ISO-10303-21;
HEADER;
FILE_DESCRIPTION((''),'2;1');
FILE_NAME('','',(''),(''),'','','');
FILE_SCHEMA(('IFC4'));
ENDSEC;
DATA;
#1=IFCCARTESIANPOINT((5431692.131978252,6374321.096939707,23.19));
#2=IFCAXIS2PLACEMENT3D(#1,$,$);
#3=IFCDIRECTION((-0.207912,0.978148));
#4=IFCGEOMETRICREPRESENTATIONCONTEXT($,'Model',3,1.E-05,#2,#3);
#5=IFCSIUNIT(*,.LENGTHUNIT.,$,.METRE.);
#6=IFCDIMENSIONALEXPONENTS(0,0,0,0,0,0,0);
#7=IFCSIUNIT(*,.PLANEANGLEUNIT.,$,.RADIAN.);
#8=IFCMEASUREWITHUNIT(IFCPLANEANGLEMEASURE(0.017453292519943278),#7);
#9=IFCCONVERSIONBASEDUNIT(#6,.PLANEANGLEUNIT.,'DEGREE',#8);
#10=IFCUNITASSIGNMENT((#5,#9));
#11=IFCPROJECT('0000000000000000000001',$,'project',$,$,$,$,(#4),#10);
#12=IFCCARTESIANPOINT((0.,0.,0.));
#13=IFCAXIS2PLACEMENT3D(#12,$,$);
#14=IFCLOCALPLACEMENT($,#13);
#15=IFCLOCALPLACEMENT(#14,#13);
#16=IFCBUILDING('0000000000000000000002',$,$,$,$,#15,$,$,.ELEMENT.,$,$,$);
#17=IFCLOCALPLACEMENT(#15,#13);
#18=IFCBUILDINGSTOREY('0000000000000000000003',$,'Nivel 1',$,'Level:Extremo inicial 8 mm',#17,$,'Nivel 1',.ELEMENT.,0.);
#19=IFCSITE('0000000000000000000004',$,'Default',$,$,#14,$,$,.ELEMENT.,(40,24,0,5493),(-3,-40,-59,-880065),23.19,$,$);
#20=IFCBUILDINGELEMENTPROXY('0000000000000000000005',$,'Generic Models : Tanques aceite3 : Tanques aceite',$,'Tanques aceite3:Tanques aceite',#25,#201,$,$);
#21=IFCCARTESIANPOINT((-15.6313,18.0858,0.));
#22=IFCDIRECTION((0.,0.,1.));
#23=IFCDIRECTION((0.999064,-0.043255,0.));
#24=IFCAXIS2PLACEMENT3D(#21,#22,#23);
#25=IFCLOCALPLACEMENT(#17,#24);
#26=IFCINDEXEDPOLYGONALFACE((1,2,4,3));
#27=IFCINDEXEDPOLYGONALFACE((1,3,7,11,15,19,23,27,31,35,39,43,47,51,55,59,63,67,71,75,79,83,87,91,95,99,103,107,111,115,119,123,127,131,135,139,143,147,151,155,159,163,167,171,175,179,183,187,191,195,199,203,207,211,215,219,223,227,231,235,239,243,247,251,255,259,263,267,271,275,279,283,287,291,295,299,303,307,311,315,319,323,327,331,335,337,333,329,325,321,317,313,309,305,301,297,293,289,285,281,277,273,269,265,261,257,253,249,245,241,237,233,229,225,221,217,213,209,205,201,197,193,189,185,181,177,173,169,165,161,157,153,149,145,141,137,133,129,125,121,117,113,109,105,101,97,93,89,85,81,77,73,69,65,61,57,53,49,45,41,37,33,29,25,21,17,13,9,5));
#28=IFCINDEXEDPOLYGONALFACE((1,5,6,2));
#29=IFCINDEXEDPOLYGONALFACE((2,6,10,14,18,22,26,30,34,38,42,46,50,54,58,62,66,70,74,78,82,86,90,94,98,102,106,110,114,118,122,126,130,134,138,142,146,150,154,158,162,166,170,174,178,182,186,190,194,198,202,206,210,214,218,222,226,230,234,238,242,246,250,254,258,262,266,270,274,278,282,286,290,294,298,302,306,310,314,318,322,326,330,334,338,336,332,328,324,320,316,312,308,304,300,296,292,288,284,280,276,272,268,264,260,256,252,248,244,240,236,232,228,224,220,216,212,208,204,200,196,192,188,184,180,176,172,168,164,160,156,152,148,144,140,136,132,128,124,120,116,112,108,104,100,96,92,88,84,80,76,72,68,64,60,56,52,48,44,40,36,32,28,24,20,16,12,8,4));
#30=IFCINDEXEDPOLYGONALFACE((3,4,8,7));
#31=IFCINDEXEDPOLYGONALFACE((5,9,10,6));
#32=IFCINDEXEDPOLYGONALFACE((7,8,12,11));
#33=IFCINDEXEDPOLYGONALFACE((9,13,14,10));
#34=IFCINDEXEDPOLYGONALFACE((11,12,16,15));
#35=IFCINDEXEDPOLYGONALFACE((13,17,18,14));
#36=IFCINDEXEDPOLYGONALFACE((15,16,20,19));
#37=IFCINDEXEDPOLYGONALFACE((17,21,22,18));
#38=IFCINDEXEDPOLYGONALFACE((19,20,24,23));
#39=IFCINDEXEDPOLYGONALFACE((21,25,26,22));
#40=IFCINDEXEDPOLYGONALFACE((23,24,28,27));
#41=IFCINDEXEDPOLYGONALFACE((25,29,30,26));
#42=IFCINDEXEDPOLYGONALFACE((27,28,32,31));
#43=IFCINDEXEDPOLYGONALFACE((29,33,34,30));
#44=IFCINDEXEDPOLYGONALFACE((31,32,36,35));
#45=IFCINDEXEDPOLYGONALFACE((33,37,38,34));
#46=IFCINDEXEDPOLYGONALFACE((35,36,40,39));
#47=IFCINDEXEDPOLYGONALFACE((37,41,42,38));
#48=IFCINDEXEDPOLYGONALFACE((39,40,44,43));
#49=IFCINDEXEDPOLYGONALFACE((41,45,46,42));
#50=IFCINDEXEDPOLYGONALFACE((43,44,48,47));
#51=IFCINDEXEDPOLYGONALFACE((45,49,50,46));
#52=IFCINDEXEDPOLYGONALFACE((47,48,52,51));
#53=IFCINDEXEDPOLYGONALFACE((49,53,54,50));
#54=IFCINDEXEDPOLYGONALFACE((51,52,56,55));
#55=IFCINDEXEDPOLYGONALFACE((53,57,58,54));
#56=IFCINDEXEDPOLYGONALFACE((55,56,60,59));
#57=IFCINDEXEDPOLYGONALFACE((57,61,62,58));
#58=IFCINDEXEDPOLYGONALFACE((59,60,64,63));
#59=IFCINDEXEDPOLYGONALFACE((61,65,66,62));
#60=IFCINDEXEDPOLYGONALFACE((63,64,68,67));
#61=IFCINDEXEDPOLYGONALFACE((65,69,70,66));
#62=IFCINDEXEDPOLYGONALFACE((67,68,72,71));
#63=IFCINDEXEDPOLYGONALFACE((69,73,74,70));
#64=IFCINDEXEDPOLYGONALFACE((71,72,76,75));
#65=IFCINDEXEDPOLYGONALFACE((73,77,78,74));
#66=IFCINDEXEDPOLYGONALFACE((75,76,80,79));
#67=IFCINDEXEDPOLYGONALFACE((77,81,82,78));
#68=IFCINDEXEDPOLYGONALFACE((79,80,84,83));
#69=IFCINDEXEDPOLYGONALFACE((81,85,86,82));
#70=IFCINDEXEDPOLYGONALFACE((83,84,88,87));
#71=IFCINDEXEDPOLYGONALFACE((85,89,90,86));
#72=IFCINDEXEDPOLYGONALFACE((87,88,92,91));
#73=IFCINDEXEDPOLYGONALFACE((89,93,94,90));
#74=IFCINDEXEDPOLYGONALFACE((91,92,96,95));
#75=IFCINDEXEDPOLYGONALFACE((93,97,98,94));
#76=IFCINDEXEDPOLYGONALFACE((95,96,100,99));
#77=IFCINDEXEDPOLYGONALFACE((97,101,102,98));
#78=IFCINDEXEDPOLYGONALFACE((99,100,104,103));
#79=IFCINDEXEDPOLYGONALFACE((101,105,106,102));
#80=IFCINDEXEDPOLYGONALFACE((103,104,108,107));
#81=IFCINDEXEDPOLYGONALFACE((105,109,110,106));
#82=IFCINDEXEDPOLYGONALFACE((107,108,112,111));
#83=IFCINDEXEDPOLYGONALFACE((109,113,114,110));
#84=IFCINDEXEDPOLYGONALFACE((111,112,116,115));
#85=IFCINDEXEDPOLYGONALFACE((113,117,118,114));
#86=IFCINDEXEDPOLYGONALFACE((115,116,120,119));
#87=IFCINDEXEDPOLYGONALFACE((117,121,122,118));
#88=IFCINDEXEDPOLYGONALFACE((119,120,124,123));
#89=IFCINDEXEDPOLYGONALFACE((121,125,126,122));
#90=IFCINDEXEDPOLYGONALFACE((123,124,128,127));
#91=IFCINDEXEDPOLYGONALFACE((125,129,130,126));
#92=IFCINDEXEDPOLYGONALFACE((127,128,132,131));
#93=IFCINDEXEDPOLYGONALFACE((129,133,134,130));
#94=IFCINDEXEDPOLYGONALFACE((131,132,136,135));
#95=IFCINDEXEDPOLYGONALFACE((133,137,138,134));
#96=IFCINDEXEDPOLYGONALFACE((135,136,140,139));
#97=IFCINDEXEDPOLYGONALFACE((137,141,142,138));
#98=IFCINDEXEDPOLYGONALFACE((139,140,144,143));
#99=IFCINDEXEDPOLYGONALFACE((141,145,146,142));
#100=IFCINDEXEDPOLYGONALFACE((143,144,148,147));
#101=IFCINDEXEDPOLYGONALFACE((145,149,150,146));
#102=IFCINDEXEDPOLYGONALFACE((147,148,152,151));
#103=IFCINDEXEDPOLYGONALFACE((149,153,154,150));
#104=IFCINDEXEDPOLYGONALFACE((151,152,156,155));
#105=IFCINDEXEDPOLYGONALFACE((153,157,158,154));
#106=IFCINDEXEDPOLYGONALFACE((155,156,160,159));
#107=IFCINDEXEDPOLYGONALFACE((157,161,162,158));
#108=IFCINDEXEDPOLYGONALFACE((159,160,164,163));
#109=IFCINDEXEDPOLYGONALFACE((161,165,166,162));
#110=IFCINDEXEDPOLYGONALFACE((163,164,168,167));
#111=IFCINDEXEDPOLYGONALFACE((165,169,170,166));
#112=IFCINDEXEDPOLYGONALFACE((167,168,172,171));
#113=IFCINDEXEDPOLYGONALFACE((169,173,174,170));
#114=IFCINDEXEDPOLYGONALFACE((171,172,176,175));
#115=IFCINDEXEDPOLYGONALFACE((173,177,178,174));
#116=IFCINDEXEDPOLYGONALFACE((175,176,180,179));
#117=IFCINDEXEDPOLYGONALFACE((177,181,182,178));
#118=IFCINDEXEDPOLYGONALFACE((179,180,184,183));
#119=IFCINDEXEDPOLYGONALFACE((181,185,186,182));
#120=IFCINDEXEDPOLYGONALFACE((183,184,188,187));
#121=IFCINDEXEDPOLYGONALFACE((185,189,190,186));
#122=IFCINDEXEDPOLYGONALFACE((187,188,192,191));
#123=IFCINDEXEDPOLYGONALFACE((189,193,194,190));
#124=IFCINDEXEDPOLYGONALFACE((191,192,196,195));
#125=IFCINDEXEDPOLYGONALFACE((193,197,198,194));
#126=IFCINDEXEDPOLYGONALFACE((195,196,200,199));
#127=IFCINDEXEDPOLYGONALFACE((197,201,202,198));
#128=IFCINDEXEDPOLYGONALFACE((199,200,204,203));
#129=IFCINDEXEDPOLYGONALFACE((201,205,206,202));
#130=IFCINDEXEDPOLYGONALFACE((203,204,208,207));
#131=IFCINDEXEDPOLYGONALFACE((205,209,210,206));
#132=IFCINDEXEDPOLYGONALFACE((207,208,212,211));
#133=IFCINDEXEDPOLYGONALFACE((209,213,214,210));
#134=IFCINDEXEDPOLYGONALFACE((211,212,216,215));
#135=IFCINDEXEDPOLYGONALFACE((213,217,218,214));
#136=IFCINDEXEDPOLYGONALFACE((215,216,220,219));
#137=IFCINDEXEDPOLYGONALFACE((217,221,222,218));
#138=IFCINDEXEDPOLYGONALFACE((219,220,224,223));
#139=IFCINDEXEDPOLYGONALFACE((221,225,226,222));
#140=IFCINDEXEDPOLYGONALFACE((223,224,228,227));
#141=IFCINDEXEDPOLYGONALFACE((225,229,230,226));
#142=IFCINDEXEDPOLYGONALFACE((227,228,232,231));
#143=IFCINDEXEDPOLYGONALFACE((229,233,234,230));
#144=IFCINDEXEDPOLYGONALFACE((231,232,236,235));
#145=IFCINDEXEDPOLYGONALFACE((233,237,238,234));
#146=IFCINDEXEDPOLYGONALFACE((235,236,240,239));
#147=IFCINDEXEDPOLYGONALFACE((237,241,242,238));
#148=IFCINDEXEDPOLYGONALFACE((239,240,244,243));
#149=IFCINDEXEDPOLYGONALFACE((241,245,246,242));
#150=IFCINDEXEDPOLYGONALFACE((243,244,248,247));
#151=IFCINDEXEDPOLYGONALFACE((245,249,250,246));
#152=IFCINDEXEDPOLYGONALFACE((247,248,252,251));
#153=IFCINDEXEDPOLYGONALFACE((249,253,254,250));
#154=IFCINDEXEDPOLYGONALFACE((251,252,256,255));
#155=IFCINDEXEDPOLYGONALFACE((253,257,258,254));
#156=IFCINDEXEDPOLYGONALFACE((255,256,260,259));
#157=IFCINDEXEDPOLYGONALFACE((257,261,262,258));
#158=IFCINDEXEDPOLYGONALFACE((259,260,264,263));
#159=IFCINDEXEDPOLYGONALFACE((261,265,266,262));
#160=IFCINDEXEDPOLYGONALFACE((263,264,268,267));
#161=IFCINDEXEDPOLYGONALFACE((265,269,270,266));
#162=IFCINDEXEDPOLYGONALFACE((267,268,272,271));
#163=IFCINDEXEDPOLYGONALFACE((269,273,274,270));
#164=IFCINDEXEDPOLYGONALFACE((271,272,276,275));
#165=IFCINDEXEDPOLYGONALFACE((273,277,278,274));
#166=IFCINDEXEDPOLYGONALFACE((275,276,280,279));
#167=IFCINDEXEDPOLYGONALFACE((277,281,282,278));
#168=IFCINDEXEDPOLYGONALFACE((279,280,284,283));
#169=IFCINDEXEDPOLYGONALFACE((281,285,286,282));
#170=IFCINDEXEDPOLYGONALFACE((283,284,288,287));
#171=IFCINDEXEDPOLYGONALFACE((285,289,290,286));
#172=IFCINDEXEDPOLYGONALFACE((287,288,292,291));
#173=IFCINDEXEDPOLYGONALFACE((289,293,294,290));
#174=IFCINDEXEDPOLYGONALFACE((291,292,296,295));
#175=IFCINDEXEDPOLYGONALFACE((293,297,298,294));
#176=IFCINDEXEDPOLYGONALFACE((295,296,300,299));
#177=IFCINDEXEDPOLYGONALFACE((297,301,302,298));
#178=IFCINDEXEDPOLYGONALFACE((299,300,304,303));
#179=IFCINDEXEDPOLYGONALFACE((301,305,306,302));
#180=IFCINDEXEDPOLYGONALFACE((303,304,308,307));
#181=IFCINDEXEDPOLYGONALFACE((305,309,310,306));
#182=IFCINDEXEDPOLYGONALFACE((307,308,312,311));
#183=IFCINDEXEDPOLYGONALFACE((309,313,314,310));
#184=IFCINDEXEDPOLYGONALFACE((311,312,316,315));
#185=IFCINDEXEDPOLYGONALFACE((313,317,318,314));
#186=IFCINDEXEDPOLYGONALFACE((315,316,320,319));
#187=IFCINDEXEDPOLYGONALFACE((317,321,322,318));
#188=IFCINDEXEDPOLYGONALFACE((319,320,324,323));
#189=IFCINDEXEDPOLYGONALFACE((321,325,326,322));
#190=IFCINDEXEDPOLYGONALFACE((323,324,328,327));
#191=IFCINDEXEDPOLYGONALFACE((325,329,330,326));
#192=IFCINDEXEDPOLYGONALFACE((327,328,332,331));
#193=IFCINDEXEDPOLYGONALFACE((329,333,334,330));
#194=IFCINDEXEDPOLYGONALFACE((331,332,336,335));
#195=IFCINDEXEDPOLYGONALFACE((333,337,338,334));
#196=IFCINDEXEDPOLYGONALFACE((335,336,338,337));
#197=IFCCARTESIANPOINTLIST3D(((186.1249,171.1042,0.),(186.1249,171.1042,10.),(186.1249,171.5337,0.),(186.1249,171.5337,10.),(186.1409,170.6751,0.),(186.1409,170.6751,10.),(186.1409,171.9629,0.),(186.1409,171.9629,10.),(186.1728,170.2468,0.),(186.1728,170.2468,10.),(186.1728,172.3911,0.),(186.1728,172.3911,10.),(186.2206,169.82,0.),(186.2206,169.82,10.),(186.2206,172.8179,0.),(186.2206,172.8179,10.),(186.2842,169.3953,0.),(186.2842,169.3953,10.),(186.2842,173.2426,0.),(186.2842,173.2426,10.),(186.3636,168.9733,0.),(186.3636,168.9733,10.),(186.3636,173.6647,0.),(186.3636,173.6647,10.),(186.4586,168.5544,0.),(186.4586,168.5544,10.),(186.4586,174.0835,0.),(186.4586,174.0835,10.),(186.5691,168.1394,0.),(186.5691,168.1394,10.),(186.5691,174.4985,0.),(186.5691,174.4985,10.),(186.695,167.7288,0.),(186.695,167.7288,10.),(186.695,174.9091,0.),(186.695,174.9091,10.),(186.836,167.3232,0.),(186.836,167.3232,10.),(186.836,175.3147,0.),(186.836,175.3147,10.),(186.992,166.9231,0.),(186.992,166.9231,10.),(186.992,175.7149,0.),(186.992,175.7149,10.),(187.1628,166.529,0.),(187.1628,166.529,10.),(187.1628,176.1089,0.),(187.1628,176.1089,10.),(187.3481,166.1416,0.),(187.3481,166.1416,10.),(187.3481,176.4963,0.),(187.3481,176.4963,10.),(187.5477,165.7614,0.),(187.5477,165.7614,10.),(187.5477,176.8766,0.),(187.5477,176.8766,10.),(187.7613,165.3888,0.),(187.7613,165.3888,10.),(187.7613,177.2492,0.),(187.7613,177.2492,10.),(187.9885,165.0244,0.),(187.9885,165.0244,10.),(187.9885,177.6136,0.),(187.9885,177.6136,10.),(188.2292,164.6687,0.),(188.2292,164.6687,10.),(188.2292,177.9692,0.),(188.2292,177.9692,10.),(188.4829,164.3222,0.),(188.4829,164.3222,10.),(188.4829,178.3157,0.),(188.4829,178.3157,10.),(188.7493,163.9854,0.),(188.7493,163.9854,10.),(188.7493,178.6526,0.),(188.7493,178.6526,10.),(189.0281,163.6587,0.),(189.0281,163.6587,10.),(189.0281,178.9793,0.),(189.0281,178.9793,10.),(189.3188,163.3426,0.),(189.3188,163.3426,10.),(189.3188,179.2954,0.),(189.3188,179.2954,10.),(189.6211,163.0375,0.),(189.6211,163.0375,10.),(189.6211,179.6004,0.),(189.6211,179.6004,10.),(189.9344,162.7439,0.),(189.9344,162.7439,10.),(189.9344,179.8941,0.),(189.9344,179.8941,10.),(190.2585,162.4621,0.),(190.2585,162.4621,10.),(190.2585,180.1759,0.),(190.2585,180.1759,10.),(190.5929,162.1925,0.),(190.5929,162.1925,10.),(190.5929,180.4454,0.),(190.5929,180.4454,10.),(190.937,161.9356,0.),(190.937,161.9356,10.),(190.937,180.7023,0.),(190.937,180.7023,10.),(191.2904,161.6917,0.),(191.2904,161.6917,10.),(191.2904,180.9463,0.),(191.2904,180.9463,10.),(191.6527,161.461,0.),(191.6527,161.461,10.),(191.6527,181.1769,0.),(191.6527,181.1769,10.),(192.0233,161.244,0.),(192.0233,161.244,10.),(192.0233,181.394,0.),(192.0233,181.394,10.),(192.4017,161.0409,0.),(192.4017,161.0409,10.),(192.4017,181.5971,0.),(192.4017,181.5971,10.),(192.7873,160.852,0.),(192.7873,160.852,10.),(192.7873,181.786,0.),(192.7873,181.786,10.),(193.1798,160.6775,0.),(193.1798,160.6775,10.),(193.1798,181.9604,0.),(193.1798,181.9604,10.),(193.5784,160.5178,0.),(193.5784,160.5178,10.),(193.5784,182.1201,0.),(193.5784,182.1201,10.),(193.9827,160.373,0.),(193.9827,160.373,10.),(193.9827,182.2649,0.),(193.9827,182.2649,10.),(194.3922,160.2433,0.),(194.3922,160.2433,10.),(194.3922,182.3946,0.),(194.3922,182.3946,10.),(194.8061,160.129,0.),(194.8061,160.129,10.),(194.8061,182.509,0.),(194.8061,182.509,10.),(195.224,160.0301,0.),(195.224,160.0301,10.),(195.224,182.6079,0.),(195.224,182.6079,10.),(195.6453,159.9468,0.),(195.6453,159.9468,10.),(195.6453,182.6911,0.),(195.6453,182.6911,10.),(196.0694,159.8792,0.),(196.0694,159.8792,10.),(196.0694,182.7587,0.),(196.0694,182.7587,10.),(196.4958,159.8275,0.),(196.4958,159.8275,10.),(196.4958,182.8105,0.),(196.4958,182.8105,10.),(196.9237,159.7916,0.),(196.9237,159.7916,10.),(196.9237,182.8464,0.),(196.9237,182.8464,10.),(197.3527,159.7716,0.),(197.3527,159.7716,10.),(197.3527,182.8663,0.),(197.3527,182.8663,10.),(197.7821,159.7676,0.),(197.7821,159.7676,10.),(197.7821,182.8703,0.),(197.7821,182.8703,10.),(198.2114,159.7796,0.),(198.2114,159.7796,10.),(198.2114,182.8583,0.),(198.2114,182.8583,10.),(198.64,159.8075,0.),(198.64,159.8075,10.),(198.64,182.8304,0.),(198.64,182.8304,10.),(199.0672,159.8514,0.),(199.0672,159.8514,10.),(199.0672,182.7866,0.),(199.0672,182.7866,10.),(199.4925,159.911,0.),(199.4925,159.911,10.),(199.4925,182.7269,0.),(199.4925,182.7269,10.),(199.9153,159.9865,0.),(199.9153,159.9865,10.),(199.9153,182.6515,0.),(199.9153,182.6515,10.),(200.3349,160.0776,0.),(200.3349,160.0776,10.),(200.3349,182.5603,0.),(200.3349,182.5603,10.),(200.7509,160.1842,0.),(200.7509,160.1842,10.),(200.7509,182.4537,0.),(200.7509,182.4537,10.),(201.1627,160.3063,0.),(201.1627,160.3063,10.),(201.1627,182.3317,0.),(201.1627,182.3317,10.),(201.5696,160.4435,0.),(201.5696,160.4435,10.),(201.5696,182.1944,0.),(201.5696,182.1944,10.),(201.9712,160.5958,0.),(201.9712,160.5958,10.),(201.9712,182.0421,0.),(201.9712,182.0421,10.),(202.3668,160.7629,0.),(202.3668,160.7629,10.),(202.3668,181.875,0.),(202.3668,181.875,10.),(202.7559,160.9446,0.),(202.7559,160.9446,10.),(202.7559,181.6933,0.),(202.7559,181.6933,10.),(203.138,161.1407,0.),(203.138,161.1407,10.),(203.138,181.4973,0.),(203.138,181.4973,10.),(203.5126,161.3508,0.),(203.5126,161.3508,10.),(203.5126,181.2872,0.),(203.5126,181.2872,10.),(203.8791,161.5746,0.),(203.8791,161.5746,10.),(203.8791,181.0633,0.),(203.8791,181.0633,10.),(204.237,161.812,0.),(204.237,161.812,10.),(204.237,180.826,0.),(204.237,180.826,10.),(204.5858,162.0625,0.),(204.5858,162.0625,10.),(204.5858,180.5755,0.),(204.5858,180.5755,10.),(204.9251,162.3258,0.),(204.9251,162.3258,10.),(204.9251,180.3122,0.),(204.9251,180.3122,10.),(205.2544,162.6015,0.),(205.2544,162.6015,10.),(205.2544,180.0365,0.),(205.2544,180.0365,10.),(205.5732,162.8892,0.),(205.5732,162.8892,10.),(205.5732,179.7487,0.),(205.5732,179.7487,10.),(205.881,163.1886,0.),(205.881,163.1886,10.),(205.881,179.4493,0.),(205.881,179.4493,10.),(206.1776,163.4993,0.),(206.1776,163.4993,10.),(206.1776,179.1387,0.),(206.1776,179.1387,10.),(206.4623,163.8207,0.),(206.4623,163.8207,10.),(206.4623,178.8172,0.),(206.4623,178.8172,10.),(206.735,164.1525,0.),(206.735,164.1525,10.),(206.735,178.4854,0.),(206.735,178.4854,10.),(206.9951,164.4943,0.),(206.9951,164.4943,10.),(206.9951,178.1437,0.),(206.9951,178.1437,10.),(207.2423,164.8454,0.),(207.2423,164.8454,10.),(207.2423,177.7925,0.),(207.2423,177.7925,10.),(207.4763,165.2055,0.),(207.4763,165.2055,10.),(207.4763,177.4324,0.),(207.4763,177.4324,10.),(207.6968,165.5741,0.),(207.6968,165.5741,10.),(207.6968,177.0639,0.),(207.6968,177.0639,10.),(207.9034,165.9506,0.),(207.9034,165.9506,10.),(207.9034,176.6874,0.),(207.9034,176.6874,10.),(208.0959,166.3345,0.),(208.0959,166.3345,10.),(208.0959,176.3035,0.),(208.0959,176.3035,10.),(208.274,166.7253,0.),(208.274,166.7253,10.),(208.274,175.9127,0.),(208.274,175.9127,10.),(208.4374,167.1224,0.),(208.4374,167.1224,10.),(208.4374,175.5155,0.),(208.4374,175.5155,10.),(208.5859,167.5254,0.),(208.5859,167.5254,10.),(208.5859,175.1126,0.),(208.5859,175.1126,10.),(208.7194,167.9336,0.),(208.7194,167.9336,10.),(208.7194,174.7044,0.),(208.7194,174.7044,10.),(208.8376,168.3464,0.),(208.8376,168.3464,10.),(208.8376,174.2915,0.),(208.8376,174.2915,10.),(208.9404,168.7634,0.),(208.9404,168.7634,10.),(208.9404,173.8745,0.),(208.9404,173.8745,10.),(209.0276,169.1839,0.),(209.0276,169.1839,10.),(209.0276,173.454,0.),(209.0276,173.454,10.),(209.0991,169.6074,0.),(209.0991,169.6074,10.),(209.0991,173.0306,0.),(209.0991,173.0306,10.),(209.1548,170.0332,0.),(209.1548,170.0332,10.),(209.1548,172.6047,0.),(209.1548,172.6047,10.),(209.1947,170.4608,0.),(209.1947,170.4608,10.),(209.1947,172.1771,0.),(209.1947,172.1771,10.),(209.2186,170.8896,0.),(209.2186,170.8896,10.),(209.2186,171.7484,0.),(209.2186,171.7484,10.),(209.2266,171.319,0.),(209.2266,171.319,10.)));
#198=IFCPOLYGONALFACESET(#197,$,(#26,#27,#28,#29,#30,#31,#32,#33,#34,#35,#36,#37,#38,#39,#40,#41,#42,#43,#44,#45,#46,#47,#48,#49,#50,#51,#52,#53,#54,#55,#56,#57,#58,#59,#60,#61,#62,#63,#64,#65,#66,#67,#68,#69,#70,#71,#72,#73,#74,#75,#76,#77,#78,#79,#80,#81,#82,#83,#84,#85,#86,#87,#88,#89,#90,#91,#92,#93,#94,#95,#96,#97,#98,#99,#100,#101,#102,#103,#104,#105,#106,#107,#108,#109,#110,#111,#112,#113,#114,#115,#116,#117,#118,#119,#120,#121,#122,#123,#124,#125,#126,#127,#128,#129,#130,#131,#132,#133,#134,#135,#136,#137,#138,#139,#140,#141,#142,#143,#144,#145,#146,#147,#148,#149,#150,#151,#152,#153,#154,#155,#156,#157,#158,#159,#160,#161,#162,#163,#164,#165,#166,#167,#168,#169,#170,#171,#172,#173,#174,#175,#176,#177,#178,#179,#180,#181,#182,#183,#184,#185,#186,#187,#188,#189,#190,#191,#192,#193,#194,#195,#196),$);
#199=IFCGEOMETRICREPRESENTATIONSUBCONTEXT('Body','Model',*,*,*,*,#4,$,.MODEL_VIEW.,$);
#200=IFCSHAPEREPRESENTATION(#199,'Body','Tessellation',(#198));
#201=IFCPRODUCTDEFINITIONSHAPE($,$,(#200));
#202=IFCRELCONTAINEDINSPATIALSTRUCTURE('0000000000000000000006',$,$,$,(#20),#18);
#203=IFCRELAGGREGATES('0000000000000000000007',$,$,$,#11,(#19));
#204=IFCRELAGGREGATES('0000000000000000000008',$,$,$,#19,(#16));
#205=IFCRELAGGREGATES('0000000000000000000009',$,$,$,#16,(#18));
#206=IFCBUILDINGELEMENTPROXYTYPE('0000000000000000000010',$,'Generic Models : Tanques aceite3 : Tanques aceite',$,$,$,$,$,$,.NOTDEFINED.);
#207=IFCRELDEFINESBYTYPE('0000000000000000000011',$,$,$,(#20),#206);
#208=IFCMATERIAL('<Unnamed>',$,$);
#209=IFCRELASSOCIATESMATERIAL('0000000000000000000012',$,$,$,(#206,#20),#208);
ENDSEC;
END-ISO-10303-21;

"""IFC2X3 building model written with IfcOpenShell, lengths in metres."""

from ifc_helpers import new_model, entity, si_unit, converted_unit, direction, frame, origin, origin_2d_with_axis, place, context, subcontext, project, spatial, circle, extrude, source, transform, mapped, material, type_object, type_shapes, element, save


model = new_model("IFC2X3")

# Units and contexts
model_context = context("Model", 3, precision=1e-05, world=frame((5431692.131978252, 6374321.096939707, 23.19)), true_north=direction((-0.207912, 0.978148)))
body_context = subcontext(model_context, "Body", "Model", "MODEL_VIEW")
ifc_project = project(units=[si_unit("LENGTHUNIT", "METRE"), converted_unit("PLANEANGLEUNIT", "DEGREE", entity("IfcPlaneAngleMeasure", 0.017453292519943278), si_unit("PLANEANGLEUNIT", "RADIAN"), dimensions=[0, 0, 0, 0, 0, 0, 0])], contexts=[model_context])

# Site, building, storey
site_placement = place(None, origin())
site = spatial("IfcSite", under=ifc_project, at=site_placement, Name="Default", CompositionType="ELEMENT", RefLatitude=(40, 24, 0, 5493), RefLongitude=(-3, -40, -59, -880065), RefElevation=23.19)
building_placement = place(site_placement, origin())
building = spatial("IfcBuilding", under=site, at=building_placement, CompositionType="ELEMENT")
storey_placement = place(building_placement, origin())
storey = spatial("IfcBuildingStorey", under=building, at=storey_placement, Name="Nivel 1", ObjectType="Level:Extremo inicial 8 mm", LongName="Nivel 1", CompositionType="ELEMENT", Elevation=0.0)

# Building element proxy
ifc_material_1 = material(Name="<Unnamed>")
building_element_proxy_type_1 = type_object("IfcBuildingElementProxyType", Name="Generic Models : Tanques aceite3 : Tanques aceite", PredefinedType="NOTDEFINED", material=ifc_material_1)
shared_shape_1 = source(origin(), body_context, "Body", "SweptSolid", [
    extrude(circle(Radius=11.5518, at=origin_2d_with_axis()), frame((197.6748, 171.319, 0.0)), (0.0, 0.0, 1.0), 10.0),
])
type_shapes(building_element_proxy_type_1, [shared_shape_1])
proxy_1_placement = place(storey_placement, frame((-15.6313, 18.0858, 0.0), z_axis=(0.0, 0.0, 1.0), x_axis=(0.999064, -0.043255, 0.0)))
element("IfcBuildingElementProxy", 1, at=proxy_1_placement, inside=storey, type_object=building_element_proxy_type_1, material=ifc_material_1, Name="Generic Models : Tanques aceite3 : Tanques aceite", ObjectType="Tanques aceite3:Tanques aceite", context=body_context, shape_type="MappedRepresentation", body=[
    mapped(shared_shape_1, transform((0.0, 0.0, 0.0), scale=1.0)),
])

save(model, "model.ifc")
